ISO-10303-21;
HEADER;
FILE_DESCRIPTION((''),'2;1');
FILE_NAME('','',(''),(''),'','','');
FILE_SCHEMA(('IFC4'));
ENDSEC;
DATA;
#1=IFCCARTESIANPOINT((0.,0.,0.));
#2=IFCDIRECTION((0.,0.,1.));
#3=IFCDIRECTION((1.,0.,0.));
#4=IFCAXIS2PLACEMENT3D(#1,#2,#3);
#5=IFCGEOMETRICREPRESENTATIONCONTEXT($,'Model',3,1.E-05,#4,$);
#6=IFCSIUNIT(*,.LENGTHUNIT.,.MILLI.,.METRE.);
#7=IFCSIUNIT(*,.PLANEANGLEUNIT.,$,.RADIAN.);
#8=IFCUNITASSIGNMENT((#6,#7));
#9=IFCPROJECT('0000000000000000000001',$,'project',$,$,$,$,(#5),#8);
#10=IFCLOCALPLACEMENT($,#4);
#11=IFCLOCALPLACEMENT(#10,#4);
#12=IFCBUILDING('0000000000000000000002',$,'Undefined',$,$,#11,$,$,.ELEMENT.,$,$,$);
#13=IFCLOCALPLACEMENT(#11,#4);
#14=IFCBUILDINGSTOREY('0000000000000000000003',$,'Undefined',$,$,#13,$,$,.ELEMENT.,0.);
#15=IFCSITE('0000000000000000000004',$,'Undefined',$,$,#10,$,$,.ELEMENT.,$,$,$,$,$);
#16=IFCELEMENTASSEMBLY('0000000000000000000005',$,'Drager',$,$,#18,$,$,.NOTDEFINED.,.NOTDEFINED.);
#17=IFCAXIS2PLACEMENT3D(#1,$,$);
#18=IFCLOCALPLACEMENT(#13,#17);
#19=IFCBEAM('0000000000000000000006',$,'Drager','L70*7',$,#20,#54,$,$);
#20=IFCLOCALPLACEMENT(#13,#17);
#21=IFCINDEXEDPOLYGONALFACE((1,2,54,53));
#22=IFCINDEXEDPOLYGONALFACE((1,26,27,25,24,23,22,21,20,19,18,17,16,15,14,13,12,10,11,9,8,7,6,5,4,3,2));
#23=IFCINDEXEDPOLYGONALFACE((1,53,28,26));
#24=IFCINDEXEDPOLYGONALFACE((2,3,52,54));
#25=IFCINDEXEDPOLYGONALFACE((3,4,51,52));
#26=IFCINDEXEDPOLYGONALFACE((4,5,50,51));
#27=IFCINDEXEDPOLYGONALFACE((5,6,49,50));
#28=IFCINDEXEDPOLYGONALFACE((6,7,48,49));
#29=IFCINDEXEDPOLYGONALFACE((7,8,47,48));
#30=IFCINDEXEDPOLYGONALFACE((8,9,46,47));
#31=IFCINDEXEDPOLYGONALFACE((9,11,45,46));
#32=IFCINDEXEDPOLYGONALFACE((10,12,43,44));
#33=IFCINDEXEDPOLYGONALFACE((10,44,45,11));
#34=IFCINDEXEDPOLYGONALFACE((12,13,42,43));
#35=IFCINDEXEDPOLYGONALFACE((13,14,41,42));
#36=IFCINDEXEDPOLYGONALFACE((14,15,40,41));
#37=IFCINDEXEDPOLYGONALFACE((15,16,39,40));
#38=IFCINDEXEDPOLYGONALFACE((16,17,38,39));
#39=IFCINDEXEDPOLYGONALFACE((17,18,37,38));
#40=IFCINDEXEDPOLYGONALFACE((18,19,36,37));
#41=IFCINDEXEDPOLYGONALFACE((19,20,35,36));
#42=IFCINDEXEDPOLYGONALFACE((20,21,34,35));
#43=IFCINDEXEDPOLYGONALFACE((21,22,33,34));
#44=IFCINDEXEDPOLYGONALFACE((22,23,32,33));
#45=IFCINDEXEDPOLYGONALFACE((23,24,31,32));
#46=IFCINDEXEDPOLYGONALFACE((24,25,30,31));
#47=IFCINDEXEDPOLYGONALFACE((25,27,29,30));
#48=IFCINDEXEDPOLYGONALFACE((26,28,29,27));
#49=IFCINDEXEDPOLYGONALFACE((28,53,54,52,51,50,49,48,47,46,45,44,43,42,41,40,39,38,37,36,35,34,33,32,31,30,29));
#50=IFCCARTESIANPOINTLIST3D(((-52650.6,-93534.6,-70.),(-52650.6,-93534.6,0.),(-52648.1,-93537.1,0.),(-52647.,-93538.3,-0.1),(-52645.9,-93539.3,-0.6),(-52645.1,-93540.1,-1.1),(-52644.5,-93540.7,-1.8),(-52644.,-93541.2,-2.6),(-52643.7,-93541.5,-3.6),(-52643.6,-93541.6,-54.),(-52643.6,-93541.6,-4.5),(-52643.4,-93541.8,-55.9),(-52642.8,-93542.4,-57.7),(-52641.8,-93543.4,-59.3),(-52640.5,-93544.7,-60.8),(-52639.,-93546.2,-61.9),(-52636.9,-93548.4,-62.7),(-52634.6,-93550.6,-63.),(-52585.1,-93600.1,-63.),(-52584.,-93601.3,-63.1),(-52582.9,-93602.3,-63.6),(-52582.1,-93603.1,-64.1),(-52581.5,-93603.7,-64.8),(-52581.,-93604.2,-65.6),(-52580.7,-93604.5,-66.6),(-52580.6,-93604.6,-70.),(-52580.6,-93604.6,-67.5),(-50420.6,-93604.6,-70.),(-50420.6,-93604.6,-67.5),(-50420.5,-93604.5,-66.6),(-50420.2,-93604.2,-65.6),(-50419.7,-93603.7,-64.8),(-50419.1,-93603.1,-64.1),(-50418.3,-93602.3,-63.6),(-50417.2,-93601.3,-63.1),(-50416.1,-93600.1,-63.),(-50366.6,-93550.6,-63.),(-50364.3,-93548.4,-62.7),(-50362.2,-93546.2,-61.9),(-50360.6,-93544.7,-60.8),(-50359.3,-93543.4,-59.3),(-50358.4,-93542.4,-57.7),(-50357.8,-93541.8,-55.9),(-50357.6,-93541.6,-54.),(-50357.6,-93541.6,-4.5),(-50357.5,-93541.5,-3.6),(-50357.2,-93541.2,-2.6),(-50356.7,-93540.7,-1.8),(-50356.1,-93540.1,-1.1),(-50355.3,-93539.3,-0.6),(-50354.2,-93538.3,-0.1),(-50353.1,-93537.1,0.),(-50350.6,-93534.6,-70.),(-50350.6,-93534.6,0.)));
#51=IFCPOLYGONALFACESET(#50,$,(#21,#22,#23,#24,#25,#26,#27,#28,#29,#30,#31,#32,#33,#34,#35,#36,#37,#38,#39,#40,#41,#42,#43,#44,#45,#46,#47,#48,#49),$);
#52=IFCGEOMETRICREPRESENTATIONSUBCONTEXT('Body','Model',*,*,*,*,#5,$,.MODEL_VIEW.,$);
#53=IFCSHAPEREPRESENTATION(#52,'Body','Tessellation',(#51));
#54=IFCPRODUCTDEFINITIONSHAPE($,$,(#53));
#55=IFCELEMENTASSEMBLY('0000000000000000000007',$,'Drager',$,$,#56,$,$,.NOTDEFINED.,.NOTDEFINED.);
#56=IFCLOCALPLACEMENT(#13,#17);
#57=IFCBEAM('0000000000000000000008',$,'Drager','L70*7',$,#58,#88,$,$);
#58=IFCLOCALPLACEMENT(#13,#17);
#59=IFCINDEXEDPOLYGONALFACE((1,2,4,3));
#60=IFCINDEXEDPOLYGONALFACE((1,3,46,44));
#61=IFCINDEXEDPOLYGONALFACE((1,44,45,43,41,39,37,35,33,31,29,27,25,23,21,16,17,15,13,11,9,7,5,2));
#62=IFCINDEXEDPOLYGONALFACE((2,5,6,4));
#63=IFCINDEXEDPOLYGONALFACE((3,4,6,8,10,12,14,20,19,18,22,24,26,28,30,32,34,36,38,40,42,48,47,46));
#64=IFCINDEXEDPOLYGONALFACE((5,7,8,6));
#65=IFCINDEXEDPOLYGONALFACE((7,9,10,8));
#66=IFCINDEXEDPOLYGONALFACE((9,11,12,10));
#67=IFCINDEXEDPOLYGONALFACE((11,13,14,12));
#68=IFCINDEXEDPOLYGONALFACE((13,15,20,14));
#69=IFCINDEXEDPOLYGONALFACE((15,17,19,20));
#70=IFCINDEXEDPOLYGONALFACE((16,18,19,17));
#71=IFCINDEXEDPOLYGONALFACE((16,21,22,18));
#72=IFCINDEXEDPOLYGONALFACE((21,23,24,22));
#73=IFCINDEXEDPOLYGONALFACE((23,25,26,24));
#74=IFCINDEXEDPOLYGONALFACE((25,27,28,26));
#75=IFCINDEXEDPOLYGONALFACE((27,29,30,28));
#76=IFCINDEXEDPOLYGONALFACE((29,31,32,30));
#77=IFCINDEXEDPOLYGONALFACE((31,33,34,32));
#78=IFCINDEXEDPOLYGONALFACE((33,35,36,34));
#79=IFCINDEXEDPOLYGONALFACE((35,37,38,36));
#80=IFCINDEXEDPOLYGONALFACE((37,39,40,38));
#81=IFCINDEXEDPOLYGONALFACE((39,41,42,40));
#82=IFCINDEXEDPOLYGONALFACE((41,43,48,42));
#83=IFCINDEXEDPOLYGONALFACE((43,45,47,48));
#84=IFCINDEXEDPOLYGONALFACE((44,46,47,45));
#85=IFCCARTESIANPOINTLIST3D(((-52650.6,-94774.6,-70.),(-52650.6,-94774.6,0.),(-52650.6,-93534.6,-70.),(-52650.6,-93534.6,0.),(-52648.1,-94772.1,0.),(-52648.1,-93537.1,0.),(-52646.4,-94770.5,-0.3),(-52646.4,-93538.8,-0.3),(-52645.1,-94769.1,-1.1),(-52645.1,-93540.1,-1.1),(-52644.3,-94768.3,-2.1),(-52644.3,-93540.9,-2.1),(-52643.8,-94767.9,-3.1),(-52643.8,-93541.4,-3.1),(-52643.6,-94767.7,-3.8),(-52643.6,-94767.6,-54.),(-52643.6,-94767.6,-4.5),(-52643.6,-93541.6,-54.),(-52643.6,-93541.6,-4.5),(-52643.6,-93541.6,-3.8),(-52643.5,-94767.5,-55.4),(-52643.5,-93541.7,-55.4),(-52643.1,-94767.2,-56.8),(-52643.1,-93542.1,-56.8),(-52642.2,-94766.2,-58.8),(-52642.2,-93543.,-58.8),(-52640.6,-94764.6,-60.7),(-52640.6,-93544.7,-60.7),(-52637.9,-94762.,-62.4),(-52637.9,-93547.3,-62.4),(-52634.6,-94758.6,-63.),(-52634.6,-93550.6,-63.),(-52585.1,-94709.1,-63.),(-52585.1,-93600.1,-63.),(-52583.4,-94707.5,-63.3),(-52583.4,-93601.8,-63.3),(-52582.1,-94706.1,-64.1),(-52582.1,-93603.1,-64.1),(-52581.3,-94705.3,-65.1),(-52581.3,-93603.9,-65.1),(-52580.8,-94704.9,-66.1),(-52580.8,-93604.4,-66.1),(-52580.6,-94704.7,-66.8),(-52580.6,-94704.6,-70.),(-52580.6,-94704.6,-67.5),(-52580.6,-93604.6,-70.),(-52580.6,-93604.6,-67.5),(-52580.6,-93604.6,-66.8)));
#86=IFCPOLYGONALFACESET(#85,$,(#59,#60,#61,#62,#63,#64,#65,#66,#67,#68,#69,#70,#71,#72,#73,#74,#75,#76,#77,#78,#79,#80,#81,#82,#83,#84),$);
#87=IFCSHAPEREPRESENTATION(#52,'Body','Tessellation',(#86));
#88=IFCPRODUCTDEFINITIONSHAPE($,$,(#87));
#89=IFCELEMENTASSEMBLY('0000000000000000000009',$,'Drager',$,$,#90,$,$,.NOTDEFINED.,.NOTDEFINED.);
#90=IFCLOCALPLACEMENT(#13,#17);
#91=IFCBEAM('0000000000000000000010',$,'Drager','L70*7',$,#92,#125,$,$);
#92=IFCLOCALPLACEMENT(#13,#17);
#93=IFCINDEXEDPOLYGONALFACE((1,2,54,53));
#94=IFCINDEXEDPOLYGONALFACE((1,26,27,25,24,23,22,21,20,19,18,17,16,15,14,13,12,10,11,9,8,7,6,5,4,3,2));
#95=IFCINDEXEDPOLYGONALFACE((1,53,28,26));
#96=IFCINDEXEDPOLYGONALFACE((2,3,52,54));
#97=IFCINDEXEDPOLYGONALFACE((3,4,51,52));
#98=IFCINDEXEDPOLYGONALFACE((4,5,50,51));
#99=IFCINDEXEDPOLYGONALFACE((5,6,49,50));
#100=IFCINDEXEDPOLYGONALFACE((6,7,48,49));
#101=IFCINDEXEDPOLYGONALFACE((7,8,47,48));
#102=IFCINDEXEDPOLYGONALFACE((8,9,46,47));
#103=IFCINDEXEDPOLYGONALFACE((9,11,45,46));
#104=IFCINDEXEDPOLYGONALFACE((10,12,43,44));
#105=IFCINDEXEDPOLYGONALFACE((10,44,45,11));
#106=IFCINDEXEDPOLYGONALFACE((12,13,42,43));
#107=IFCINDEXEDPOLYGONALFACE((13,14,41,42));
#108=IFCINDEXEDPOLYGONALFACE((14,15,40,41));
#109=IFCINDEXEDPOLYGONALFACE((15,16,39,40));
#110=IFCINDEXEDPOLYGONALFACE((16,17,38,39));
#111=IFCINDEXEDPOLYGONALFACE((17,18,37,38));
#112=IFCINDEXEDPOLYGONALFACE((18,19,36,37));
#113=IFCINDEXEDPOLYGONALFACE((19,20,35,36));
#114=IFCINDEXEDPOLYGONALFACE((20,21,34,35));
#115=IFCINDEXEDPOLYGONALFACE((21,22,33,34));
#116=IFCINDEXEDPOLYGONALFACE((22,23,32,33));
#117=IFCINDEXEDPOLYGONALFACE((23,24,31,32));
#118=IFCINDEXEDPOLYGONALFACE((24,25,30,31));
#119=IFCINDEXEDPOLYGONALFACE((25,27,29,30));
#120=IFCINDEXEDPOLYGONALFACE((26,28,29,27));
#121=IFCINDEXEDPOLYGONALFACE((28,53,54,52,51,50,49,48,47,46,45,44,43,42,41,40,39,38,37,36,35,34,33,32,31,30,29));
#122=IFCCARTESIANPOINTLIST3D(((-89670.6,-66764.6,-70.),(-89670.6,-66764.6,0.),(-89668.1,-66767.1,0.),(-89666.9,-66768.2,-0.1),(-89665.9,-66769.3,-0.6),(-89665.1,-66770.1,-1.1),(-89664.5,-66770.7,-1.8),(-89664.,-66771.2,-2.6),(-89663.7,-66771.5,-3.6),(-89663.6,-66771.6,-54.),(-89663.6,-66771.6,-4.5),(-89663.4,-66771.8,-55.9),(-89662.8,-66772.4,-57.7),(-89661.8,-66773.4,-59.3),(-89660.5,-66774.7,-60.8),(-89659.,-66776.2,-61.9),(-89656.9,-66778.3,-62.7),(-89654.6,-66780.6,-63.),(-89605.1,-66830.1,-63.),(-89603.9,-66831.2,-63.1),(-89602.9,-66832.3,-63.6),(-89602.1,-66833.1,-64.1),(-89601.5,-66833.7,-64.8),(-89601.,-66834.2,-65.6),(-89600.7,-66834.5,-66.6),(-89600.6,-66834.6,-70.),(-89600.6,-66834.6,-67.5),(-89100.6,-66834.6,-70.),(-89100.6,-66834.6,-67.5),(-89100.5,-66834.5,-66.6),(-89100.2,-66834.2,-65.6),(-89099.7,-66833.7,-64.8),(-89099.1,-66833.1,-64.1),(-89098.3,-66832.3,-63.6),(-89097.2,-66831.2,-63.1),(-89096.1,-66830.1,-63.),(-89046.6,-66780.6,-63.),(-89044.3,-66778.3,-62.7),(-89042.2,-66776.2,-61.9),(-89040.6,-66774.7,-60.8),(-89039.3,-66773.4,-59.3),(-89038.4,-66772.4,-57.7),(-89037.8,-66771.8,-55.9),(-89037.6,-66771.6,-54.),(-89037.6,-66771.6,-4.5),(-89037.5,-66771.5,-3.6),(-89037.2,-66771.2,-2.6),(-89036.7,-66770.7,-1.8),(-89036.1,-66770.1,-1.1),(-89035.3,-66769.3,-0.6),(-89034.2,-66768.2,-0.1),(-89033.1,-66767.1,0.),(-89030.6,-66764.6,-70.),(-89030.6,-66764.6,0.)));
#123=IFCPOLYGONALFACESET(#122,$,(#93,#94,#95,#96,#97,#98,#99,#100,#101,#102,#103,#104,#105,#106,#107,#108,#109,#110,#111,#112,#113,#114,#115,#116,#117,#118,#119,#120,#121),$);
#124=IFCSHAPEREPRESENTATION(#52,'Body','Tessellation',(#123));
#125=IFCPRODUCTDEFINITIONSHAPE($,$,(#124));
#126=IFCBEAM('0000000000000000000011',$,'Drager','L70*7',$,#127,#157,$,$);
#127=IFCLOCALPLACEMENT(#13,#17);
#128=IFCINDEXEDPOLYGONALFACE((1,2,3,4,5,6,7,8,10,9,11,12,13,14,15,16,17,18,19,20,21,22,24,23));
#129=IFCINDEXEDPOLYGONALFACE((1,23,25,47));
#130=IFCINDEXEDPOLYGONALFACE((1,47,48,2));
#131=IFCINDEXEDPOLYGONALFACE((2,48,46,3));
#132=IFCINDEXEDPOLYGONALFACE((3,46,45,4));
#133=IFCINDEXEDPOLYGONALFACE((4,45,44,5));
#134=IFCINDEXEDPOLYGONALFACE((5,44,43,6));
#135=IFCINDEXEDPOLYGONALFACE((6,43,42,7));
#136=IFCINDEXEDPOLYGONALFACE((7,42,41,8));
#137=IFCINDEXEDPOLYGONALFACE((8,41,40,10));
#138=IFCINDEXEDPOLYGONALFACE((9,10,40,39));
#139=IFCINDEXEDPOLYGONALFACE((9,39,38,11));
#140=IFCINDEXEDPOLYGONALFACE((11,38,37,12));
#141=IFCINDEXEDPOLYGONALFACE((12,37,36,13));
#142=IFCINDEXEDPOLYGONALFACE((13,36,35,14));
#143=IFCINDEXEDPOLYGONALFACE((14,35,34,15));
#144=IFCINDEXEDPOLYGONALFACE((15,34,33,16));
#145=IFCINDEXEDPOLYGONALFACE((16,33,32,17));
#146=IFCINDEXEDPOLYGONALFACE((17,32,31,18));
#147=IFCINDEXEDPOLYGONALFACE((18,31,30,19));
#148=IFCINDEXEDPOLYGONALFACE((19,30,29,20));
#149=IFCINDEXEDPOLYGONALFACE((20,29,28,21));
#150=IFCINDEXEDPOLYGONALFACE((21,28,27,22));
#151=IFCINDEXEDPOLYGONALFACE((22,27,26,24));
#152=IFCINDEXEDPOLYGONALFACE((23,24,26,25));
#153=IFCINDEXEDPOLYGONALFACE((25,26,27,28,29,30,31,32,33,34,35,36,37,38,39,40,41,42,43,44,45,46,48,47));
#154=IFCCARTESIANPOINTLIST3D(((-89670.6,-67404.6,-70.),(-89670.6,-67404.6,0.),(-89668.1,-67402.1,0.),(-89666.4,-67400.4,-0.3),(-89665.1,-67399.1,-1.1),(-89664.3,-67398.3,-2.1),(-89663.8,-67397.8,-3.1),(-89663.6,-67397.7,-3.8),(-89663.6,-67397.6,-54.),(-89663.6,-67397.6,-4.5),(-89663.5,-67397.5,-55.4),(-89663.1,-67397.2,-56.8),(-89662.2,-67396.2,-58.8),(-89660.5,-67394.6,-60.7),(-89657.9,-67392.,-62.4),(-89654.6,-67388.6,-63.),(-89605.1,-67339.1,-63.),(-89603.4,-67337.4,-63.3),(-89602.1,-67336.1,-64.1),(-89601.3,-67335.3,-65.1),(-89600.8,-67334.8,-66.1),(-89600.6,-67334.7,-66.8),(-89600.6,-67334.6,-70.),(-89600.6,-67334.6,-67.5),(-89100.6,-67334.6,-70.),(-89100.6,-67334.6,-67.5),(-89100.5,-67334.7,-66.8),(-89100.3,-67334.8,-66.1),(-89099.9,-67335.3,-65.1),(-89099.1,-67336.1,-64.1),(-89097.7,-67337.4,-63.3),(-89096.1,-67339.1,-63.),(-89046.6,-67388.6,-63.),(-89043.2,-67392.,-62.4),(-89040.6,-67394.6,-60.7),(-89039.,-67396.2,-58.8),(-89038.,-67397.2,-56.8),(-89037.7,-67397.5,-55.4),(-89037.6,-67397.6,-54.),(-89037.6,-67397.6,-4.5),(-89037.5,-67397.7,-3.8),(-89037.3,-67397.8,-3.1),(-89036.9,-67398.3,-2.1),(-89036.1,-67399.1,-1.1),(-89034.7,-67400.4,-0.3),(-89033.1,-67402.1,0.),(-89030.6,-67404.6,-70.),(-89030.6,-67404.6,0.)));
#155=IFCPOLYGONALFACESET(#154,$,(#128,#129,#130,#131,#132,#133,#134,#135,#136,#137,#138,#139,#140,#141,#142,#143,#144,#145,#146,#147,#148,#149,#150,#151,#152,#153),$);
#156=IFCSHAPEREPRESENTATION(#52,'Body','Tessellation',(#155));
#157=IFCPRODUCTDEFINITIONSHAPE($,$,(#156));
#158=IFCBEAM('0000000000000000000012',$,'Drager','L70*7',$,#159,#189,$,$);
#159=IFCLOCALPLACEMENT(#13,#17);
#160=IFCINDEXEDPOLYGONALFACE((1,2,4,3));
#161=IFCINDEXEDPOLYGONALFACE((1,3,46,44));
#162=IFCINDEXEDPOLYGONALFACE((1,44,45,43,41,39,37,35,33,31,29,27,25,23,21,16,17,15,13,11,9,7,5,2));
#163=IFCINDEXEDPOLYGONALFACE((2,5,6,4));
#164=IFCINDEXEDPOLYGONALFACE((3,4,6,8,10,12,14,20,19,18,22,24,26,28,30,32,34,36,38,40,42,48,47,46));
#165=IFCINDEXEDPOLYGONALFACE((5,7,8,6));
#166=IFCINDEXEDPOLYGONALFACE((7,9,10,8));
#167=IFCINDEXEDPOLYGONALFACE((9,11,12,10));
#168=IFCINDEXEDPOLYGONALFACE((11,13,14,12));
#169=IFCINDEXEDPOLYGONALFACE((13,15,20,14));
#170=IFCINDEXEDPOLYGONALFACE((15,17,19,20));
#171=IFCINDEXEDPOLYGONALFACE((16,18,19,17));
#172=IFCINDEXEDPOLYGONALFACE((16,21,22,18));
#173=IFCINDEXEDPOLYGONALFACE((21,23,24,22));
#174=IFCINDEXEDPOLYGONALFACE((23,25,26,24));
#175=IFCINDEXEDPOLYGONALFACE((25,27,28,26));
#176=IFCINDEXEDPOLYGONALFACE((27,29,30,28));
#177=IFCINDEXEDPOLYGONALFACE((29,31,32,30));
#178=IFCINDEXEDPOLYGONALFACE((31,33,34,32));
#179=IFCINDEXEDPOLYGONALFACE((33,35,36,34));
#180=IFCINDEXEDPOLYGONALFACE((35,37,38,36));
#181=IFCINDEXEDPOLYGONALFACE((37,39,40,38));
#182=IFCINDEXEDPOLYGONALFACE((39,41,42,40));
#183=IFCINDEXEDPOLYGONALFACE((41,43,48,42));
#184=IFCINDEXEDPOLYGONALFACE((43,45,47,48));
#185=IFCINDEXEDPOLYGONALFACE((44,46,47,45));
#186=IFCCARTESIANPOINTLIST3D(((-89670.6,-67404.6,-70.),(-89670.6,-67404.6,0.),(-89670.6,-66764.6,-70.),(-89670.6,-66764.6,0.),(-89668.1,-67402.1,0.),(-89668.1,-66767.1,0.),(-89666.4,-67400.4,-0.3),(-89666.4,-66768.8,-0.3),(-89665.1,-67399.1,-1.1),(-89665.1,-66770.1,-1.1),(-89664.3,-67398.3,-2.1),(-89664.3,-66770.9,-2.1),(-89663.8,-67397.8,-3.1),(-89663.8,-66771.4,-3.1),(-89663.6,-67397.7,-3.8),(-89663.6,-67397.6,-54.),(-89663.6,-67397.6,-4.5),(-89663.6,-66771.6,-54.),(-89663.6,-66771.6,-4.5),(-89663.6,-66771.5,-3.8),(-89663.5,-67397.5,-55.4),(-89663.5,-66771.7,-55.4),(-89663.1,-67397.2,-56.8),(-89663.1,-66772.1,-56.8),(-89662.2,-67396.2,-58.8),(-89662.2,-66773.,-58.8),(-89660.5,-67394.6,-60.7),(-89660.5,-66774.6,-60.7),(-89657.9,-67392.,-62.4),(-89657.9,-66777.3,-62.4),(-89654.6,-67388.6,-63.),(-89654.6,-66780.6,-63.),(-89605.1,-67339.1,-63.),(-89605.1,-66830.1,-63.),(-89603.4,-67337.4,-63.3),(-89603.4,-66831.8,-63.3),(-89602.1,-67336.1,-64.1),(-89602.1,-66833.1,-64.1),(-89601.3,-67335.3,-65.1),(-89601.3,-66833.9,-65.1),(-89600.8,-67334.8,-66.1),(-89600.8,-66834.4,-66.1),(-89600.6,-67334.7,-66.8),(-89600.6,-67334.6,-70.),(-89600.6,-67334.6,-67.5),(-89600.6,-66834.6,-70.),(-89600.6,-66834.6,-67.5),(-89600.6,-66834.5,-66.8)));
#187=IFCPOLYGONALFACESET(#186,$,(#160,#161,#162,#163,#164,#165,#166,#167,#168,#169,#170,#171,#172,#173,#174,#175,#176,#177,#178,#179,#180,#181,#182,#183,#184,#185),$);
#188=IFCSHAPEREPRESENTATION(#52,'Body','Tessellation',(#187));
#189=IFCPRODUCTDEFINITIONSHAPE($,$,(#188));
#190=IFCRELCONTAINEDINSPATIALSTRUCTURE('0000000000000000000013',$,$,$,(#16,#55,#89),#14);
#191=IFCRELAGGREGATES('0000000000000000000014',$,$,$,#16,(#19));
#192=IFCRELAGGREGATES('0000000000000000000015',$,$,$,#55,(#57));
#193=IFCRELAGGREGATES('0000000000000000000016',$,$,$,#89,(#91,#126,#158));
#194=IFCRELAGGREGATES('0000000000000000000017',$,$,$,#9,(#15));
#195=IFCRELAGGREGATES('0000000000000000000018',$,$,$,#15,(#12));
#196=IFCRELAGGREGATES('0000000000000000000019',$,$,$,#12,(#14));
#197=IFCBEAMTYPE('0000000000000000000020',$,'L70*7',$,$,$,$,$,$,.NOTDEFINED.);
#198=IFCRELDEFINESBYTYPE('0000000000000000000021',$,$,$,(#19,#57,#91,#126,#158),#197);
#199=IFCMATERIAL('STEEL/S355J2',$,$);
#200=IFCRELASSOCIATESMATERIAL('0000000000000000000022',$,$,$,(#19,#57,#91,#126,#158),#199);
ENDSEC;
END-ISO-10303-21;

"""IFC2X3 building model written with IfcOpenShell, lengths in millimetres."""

from ifc_helpers import new_model, si_unit, frame, origin_with_axes, origin_2d_with_axis, place, context, subcontext, project, spatial, l_section, extrude, clip, halfspace, material, type_object, element, aggregate, save


model = new_model("IFC2X3")

# Units and contexts
model_context = context("Model", 3, precision=1e-05, world=origin_with_axes())
body_context = subcontext(model_context, "Body", "Model", "MODEL_VIEW")
ifc_project = project(units=[si_unit("LENGTHUNIT", "METRE", prefix="MILLI"), si_unit("PLANEANGLEUNIT", "RADIAN")], contexts=[model_context])

# Site, building, storey
site_placement = place(None, origin_with_axes())
site = spatial("IfcSite", under=ifc_project, at=site_placement, Name="Undefined", CompositionType="ELEMENT")
building_placement = place(site_placement, origin_with_axes())
building = spatial("IfcBuilding", under=site, at=building_placement, Name="Undefined", CompositionType="ELEMENT")
storey_placement = place(building_placement, origin_with_axes())
storey = spatial("IfcBuildingStorey", under=building, at=storey_placement, Name="Undefined", CompositionType="ELEMENT", Elevation=0.0)

# Element assemblies, beams
assembly_1_placement = place(storey_placement, origin_with_axes())
assembly_1 = element("IfcElementAssembly", 1, at=assembly_1_placement, inside=storey, Name="Drager", AssemblyPlace="NOTDEFINED", PredefinedType="NOTDEFINED")
ifc_material_1 = material(Name="STEEL/S355J2")
beam_type_1 = type_object("IfcBeamType", Name="L70*7", PredefinedType="NOTDEFINED")
beam_1_placement = place(assembly_1_placement, frame((-52580.6, -93569.6, -35.0), z_axis=(0.0, 0.0, 1.0), x_axis=(1.0, 0.0, 0.0)))
beam_1 = element("IfcBeam", 2, at=beam_1_placement, type_object=beam_type_1, material=ifc_material_1, Name="Drager", Description="L70*7", context=body_context, shape_type="Clipping", body=[
    clip(clip(extrude(l_section(Depth=70.0, Width=70.0, Thickness=7.0, FilletRadius=9.0, EdgeRadius=4.5, at=origin_2d_with_axis()), frame((2265.7, 0.0, 0.0), z_axis=(-1.0, 0.0, 0.0), x_axis=(0.0, -1.0, 0.0)), (0.0, 0.0, 1.0), 2371.4), halfspace(frame((2160.0, -35.0, 35.0), z_axis=(-0.707107, 0.707107, 0.0), x_axis=(0.707107, 0.707107, 0.0)), True)), halfspace(frame((0.0, -35.0, 35.0), z_axis=(-0.707107, -0.707107, 0.0), x_axis=(-0.707107, 0.707107, 0.0)), False)),
])
aggregate(assembly_1, [beam_1])
assembly_2_placement = place(storey_placement, origin_with_axes())
assembly_2 = element("IfcElementAssembly", 3, at=assembly_2_placement, inside=storey, Name="Drager", AssemblyPlace="NOTDEFINED", PredefinedType="NOTDEFINED")
beam_2_placement = place(assembly_2_placement, frame((-52615.6, -94704.6, -35.0), z_axis=(0.0, 0.0, 1.0), x_axis=(0.0, 1.0, 0.0)))
beam_2 = element("IfcBeam", 4, at=beam_2_placement, type_object=beam_type_1, material=ifc_material_1, Name="Drager", Description="L70*7", context=body_context, shape_type="Clipping", body=[
    clip(clip(extrude(l_section(Depth=70.0, Width=70.0, Thickness=7.0, FilletRadius=9.0, EdgeRadius=4.5, at=origin_2d_with_axis()), frame((1205.7, 0.0, 0.0), z_axis=(-1.0, 0.0, 0.0), x_axis=(0.0, -1.0, 0.0)), (0.0, 0.0, 1.0), 1311.4), halfspace(frame((1100.0, -35.0, 35.0), z_axis=(0.707107, -0.707107, 0.0), x_axis=(0.0, 0.0, 1.0)), False)), halfspace(frame((0.0, -35.0, 35.0), z_axis=(0.707107, 0.707107, 0.0), x_axis=(0.0, 0.0, 1.0)), True)),
])
aggregate(assembly_2, [beam_2])

# Element assembly, beams
assembly_3_placement = place(storey_placement, origin_with_axes())
assembly_3 = element("IfcElementAssembly", 5, at=assembly_3_placement, inside=storey, Name="Drager", AssemblyPlace="NOTDEFINED", PredefinedType="NOTDEFINED")
beam_3_placement = place(assembly_3_placement, frame((-89600.6, -66799.6, -35.0), z_axis=(0.0, 0.0, 1.0), x_axis=(1.0, 0.000003, 0.0)))
beam_3 = element("IfcBeam", 6, at=beam_3_placement, type_object=beam_type_1, material=ifc_material_1, Name="Drager", Description="L70*7", context=body_context, shape_type="Clipping", body=[
    clip(clip(extrude(l_section(Depth=70.0, Width=70.0, Thickness=7.0, FilletRadius=9.0, EdgeRadius=4.5, at=origin_2d_with_axis()), frame((605.7, 0.0, 0.0), z_axis=(-1.0, 0.0, 0.0), x_axis=(0.0, -1.0, 0.0)), (0.0, 0.0, 1.0), 711.4), halfspace(frame((500.0, -35.0, 35.0), z_axis=(-0.707107, 0.707107, 0.0), x_axis=(0.707107, 0.707107, 0.0)), True)), halfspace(frame((0.0, -35.0, 35.0), z_axis=(-0.707107, -0.707107, 0.0), x_axis=(-0.707107, 0.707107, 0.0)), False)),
])
beam_4_placement = place(assembly_3_placement, frame((-89100.6, -67369.6, -35.0), z_axis=(0.0, 0.0, 1.0), x_axis=(-1.0, 0.0, 0.0)))
beam_4 = element("IfcBeam", 7, at=beam_4_placement, type_object=beam_type_1, material=ifc_material_1, Name="Drager", Description="L70*7", context=body_context, shape_type="Clipping", body=[
    clip(clip(extrude(l_section(Depth=70.0, Width=70.0, Thickness=7.0, FilletRadius=9.0, EdgeRadius=4.5, at=origin_2d_with_axis()), frame((605.7, 0.0, 0.0), z_axis=(-1.0, 0.0, 0.0), x_axis=(0.0, -1.0, 0.0)), (0.0, 0.0, 1.0), 711.4), halfspace(frame((500.0, -35.0, 35.0), z_axis=(0.707107, -0.707107, 0.0), x_axis=(0.0, 0.0, 1.0)), False)), halfspace(frame((0.0, -35.0, 35.0), z_axis=(0.707107, 0.707107, 0.0), x_axis=(0.0, 0.0, 1.0)), True)),
])
beam_5_placement = place(assembly_3_placement, frame((-89635.6, -67334.6, -35.0), z_axis=(0.0, 0.0, 1.0), x_axis=(0.0, 1.0, 0.0)))
beam_5 = element("IfcBeam", 8, at=beam_5_placement, type_object=beam_type_1, material=ifc_material_1, Name="Drager", Description="L70*7", context=body_context, shape_type="Clipping", body=[
    clip(clip(extrude(l_section(Depth=70.0, Width=70.0, Thickness=7.0, FilletRadius=9.0, EdgeRadius=4.5, at=origin_2d_with_axis()), frame((605.7, 0.0, 0.0), z_axis=(-1.0, 0.0, 0.0), x_axis=(0.0, -1.0, 0.0)), (0.0, 0.0, 1.0), 711.4), halfspace(frame((500.0, -35.0, 35.0), z_axis=(0.707107, -0.707107, 0.0), x_axis=(0.0, 0.0, 1.0)), False)), halfspace(frame((0.0, -35.0, 35.0), z_axis=(0.707107, 0.707107, 0.0), x_axis=(0.0, 0.0, 1.0)), True)),
])
aggregate(assembly_3, [beam_3, beam_4, beam_5])

save(model, "model.ifc")
